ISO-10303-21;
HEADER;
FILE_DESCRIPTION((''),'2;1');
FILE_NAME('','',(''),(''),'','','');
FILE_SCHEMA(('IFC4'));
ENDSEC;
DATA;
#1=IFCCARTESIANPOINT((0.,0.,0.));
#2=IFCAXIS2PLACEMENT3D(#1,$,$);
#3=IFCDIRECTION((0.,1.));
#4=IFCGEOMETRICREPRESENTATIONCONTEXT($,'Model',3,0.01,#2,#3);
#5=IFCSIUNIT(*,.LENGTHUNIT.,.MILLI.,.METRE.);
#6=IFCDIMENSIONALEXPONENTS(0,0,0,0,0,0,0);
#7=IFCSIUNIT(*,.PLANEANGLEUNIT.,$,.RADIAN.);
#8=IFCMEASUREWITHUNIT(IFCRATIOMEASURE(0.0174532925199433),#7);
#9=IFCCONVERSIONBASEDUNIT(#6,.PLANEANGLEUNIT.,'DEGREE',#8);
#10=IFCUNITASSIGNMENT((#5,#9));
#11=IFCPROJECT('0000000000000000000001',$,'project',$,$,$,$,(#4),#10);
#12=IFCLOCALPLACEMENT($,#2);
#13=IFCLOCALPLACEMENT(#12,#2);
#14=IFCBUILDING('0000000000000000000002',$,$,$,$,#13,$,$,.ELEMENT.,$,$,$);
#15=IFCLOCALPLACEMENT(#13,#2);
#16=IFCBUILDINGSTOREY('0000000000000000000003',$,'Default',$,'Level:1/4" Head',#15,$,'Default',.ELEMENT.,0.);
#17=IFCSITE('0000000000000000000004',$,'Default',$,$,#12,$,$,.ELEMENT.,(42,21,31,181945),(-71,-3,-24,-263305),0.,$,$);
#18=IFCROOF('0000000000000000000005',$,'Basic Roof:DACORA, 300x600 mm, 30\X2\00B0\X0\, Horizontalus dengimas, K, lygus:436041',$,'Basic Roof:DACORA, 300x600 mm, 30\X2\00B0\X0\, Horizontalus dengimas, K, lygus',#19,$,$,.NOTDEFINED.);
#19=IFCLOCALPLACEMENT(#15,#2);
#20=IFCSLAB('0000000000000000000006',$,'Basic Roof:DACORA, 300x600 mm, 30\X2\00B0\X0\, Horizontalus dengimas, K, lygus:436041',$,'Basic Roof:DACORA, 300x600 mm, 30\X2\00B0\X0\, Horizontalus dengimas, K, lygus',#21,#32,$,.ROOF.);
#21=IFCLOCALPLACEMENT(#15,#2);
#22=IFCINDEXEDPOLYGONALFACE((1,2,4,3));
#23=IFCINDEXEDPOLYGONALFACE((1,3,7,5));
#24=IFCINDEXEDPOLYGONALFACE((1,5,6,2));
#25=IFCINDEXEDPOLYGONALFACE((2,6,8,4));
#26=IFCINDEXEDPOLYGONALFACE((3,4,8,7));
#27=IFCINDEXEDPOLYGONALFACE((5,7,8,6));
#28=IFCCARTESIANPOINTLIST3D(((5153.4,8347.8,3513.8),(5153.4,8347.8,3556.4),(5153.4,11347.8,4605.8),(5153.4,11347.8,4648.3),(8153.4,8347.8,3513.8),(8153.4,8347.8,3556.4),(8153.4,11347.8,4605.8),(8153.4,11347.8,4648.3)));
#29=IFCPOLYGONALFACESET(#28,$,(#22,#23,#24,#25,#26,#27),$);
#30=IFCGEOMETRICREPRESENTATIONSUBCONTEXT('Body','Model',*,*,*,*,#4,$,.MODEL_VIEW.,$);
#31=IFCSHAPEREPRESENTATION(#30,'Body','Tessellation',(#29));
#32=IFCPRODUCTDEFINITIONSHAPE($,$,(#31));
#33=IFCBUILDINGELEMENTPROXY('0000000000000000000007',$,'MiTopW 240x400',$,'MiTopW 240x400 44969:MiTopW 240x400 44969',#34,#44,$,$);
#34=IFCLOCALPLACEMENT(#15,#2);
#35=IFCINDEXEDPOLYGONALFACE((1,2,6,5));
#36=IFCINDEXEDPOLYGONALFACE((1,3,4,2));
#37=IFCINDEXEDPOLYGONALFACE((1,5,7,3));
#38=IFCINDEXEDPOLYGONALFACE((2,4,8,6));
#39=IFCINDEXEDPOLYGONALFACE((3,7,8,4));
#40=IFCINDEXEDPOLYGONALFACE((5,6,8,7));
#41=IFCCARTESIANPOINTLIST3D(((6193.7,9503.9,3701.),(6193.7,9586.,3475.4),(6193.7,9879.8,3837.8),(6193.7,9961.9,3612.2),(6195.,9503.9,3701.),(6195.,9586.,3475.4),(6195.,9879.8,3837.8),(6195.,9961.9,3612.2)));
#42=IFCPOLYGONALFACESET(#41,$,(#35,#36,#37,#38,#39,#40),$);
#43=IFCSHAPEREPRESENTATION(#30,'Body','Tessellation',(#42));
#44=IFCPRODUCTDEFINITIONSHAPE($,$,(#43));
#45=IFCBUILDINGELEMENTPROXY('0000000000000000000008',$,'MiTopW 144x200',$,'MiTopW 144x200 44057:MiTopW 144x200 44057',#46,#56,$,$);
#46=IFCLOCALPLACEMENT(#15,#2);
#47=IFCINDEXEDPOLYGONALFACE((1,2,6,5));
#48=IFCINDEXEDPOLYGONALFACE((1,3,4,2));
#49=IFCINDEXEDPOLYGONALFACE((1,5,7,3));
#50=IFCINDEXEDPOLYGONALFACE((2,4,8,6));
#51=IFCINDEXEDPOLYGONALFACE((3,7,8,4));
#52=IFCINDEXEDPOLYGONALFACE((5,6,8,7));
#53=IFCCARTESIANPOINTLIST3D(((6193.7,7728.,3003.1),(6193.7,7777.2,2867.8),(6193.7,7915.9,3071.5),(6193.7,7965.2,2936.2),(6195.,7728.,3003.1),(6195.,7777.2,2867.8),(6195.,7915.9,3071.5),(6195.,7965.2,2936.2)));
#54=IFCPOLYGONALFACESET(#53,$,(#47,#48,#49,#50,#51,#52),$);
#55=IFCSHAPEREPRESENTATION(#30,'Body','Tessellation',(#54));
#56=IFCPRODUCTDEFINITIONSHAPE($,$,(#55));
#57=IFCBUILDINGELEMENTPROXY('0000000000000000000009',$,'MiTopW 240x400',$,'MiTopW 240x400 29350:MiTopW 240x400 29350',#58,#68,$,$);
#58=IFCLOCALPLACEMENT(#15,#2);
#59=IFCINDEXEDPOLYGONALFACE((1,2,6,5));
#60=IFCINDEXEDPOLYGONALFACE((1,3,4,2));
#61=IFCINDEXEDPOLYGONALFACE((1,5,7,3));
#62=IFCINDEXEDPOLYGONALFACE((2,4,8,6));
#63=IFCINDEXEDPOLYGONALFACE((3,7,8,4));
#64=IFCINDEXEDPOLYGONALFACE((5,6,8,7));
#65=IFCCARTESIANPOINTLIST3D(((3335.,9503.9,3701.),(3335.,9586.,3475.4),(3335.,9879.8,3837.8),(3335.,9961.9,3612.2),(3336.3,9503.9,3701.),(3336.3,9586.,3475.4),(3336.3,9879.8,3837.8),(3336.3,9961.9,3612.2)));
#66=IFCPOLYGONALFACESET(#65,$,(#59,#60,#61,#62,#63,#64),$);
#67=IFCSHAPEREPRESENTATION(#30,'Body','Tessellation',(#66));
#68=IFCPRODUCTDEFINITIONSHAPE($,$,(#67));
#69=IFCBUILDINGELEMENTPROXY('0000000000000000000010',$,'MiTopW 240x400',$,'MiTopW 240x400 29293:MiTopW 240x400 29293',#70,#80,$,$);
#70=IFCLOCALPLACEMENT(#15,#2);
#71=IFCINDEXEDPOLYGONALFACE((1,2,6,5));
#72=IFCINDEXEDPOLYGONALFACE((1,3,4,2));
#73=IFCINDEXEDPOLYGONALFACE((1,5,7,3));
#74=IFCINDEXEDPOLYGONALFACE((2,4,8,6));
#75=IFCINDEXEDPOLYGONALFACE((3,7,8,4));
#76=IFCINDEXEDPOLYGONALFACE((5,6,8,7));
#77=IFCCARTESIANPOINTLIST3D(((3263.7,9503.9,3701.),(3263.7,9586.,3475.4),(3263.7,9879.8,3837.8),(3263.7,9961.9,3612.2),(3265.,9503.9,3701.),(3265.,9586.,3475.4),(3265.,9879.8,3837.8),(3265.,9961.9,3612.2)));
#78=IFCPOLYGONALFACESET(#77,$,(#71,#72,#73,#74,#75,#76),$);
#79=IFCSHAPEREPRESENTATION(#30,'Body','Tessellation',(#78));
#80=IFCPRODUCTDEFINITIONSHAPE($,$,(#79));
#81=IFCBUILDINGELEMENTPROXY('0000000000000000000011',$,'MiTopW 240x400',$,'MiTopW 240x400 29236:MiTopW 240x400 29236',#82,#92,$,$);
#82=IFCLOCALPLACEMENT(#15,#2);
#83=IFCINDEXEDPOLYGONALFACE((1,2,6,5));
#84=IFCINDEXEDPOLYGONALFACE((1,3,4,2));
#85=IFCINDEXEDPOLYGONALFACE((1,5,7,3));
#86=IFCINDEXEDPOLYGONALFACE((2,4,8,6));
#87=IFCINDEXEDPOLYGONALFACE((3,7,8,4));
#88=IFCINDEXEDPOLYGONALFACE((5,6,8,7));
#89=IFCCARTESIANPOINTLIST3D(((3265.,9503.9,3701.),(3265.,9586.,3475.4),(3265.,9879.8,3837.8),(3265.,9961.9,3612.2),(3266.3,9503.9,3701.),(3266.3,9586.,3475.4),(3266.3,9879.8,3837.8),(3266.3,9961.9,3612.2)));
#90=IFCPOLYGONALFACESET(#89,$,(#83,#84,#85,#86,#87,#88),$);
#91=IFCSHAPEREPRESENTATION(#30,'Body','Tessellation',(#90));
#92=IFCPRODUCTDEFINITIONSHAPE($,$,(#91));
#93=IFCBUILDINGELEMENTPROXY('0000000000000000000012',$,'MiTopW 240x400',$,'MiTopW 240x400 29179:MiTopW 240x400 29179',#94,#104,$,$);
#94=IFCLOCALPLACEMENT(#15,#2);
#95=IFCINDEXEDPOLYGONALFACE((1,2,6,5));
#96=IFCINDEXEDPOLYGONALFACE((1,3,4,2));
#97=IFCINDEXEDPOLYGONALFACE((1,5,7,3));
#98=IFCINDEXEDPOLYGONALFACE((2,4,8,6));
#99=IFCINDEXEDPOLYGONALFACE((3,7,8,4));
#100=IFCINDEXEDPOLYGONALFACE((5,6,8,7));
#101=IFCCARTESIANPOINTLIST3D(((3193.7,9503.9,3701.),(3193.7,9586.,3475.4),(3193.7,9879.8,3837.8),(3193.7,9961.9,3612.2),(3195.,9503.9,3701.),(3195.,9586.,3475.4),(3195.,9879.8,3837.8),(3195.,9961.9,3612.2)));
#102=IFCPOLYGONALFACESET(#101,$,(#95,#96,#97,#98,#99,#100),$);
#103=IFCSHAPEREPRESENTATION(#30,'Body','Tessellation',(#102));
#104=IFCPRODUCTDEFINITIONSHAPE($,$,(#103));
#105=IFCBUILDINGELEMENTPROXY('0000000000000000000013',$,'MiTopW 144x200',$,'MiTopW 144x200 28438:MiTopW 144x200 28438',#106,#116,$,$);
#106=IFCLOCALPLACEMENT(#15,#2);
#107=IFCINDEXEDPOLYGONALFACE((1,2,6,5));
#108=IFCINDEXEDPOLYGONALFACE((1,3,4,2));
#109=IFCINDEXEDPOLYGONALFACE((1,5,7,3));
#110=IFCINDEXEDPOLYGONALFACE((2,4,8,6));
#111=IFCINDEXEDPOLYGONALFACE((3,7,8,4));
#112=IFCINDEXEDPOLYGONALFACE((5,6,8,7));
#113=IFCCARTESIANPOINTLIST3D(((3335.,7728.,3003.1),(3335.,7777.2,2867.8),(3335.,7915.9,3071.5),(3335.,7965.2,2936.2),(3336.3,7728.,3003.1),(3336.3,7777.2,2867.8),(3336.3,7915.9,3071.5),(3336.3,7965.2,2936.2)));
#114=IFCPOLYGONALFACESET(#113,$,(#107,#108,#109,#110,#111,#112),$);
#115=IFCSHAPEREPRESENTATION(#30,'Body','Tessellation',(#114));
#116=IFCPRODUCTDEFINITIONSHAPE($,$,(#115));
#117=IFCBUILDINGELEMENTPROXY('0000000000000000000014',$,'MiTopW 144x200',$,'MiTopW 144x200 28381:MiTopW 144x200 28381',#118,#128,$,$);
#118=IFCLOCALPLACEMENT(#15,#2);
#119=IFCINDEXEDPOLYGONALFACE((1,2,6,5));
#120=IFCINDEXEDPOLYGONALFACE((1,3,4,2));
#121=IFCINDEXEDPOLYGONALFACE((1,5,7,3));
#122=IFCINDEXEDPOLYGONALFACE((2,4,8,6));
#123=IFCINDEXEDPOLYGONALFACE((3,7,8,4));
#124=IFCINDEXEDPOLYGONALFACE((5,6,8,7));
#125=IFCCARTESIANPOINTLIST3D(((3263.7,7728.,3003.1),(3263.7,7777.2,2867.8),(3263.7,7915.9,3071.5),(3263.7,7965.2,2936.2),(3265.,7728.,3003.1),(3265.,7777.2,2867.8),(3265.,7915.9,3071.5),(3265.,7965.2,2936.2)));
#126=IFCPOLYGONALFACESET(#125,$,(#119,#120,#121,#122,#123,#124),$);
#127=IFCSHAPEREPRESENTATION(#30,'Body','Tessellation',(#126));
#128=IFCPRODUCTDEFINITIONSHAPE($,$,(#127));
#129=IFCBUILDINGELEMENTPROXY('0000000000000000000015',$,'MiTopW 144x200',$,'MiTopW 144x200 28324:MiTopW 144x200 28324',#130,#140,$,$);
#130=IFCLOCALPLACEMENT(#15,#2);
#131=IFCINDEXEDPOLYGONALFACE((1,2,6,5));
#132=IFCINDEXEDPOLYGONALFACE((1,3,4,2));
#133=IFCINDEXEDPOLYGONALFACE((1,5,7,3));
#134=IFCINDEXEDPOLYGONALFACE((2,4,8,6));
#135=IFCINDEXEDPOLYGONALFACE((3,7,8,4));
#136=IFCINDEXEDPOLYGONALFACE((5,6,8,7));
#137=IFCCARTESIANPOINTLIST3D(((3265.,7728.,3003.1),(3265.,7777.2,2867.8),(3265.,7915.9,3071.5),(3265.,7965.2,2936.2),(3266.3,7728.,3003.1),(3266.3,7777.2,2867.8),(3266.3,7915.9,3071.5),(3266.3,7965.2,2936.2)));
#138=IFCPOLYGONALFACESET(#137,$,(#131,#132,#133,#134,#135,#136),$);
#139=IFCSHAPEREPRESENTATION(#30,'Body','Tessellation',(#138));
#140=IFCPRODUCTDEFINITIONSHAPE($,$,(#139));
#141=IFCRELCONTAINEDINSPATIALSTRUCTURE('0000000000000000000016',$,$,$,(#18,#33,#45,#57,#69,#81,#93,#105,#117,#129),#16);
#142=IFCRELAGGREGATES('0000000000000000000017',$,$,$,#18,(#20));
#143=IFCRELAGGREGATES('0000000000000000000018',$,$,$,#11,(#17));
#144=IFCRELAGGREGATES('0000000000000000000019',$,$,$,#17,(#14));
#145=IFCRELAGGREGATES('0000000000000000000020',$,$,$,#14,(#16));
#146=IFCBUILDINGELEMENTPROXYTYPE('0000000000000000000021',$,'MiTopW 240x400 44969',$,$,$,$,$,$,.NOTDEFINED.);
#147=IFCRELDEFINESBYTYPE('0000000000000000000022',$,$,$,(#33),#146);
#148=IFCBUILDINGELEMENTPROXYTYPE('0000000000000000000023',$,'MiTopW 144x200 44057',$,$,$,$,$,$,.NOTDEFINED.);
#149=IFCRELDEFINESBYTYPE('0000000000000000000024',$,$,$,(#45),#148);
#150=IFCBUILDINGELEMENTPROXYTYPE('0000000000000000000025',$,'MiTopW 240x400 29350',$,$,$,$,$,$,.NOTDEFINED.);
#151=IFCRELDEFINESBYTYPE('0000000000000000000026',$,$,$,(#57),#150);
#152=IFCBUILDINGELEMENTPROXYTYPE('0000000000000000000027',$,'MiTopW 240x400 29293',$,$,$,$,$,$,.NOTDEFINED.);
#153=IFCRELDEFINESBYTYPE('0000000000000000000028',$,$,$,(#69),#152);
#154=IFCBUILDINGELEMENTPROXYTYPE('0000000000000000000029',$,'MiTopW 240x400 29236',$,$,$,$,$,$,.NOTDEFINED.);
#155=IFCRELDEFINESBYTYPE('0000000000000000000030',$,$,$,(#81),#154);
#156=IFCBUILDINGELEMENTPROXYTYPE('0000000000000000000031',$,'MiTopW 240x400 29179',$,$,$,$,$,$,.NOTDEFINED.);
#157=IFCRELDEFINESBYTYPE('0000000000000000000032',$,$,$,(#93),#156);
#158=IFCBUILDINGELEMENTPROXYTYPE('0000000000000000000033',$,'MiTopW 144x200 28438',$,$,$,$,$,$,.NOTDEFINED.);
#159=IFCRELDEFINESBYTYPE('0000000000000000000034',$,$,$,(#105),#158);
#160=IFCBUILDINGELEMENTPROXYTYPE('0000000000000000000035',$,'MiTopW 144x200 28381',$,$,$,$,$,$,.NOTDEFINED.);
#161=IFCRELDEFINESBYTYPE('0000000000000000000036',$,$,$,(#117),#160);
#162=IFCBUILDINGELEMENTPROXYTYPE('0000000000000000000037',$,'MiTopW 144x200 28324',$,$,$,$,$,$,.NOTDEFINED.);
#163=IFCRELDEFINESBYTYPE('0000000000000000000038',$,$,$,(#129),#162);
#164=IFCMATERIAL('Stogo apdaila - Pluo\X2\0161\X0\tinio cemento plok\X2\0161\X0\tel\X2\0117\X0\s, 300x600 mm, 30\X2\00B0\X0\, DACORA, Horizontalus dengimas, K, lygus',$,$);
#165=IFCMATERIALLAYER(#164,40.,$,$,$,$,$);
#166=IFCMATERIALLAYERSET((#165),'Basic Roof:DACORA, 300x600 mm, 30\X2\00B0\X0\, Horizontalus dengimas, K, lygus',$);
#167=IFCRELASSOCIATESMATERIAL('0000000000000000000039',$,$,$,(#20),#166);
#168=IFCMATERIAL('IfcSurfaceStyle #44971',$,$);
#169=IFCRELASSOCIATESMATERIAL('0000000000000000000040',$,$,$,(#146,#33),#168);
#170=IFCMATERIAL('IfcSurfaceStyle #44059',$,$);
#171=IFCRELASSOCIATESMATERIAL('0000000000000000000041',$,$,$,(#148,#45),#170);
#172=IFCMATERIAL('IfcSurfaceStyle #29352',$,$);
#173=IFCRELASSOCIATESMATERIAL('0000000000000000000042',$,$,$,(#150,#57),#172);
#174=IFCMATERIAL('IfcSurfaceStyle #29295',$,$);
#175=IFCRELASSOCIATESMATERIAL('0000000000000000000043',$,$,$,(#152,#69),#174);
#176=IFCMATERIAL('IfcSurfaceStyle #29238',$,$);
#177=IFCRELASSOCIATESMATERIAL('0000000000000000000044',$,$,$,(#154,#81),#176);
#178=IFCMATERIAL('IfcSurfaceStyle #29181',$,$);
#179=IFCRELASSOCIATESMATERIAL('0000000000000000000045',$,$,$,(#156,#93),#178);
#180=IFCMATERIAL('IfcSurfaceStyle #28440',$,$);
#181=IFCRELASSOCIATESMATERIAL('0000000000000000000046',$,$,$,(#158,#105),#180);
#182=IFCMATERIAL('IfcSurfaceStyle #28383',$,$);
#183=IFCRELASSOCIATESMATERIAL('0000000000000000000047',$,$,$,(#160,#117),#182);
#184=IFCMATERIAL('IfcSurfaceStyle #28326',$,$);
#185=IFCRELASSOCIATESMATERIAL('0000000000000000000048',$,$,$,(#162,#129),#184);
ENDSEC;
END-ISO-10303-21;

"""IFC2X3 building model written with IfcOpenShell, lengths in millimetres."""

from ifc_helpers import new_model, entity, si_unit, converted_unit, direction, frame, frame_2d, origin, place, context, subcontext, project, spatial, polyline, rectangle, outline, extrude, source, transform, mapped, material, layer, layer_set, type_object, type_shapes, element, aggregate, save


model = new_model("IFC2X3")

# Units and contexts
model_context = context("Model", 3, precision=0.01, world=origin(), true_north=direction((0.0, 1.0)))
body_context = subcontext(model_context, "Body", "Model", "MODEL_VIEW")
ifc_project = project(units=[si_unit("LENGTHUNIT", "METRE", prefix="MILLI"), converted_unit("PLANEANGLEUNIT", "DEGREE", entity("IfcRatioMeasure", 0.0174532925199433), si_unit("PLANEANGLEUNIT", "RADIAN"), dimensions=[0, 0, 0, 0, 0, 0, 0])], contexts=[model_context])

# Site, building, storey
site_placement = place(None, origin())
site = spatial("IfcSite", under=ifc_project, at=site_placement, Name="Default", CompositionType="ELEMENT", RefLatitude=(42, 21, 31, 181945), RefLongitude=(-71, -3, -24, -263305), RefElevation=0.0)
building_placement = place(site_placement, origin())
building = spatial("IfcBuilding", under=site, at=building_placement, CompositionType="ELEMENT")
storey_placement = place(building_placement, origin())
storey = spatial("IfcBuildingStorey", under=building, at=storey_placement, Name="Default", ObjectType="Level:1/4\" Head", LongName="Default", CompositionType="ELEMENT", Elevation=0.0)

# Roof, slab
roof_placement = place(storey_placement, frame((5153.4, 8347.8, 3513.8)))
roof = element("IfcRoof", 1, at=roof_placement, inside=storey, Name="Basic Roof:DACORA, 300x600 mm, 30°, Horizontalus dengimas, K, lygus:436041", ObjectType="Basic Roof:DACORA, 300x600 mm, 30°, Horizontalus dengimas, K, lygus", ShapeType="NOTDEFINED")
ifc_material_1 = material(Name="Stogo apdaila - Pluoštinio cemento plokštelės, 300x600 mm, 30°, DACORA, Horizontalus dengimas, K, lygus")
ifc_layer = layer(ifc_material_1, 40.0)
ifc_layer_set = layer_set([ifc_layer], Name="Basic Roof:DACORA, 300x600 mm, 30°, Horizontalus dengimas, K, lygus")
slab_placement = place(roof_placement, origin())
slab = element("IfcSlab", 2, at=slab_placement, material=ifc_layer_set, Name="Basic Roof:DACORA, 300x600 mm, 30°, Horizontalus dengimas, K, lygus:436041", ObjectType="Basic Roof:DACORA, 300x600 mm, 30°, Horizontalus dengimas, K, lygus", PredefinedType="ROOF", context=body_context, shape_type="SweptSolid", body=[
    extrude(rectangle(XDim=3192.5, YDim=3000.0, at=frame_2d((0.0, 0.0), x_axis=(0.0, -1.0))), frame((1500.0, 1500.0, 546.0), z_axis=(0.0, -0.34202, 0.939693), x_axis=(1.0, 0.0, 0.0)), (0.0, 0.34202, 0.939693), 42.6),
])
aggregate(roof, [slab])

# Building element proxies
ifc_material_2 = material(Name="IfcSurfaceStyle #44971")
building_element_proxy_type_1 = type_object("IfcBuildingElementProxyType", Name="MiTopW 240x400 44969", PredefinedType="NOTDEFINED", material=ifc_material_2)
shared_shape_1 = source(origin(), body_context, "Body", "SweptSolid", [
    extrude(outline(polyline([(-200.0, -120.0), (200.0, -120.0), (200.0, 120.0), (-200.0, 120.0), (-200.0, -120.0)])), frame((200.0, 120.0, 0.0), z_axis=(0.0, 0.0, 1.0), x_axis=(-1.0, 0.0, 0.0)), (0.0, 0.0, 1.0), 1.3),
])
type_shapes(building_element_proxy_type_1, [shared_shape_1])
proxy_1_placement = place(building_placement, frame((6195.0, 9961.9, 3612.2), z_axis=(-1.0, 0.0, 0.0), x_axis=(0.0, -0.939693, -0.34202)))
element("IfcBuildingElementProxy", 3, at=proxy_1_placement, inside=storey, type_object=building_element_proxy_type_1, material=ifc_material_2, Name="MiTopW 240x400", ObjectType="MiTopW 240x400 44969:MiTopW 240x400 44969", context=body_context, shape_type="MappedRepresentation", body=[
    mapped(shared_shape_1, transform((0.0, 0.0, 0.0), scale=1.0)),
])
ifc_material_3 = material(Name="IfcSurfaceStyle #44059")
building_element_proxy_type_2 = type_object("IfcBuildingElementProxyType", Name="MiTopW 144x200 44057", PredefinedType="NOTDEFINED", material=ifc_material_3)
shared_shape_2 = source(origin(), body_context, "Body", "SweptSolid", [
    extrude(outline(polyline([(-100.0, -72.0), (100.0, -72.0), (100.0, 72.0), (-100.0, 72.0), (-100.0, -72.0)])), frame((100.0, 72.0, 0.0), z_axis=(0.0, 0.0, 1.0), x_axis=(-1.0, 0.0, 0.0)), (0.0, 0.0, 1.0), 1.3),
])
type_shapes(building_element_proxy_type_2, [shared_shape_2])
proxy_2_placement = place(building_placement, frame((6195.0, 7965.2, 2936.2), z_axis=(-1.0, 0.0, 0.0), x_axis=(0.0, -0.939693, -0.34202)))
element("IfcBuildingElementProxy", 4, at=proxy_2_placement, inside=storey, type_object=building_element_proxy_type_2, material=ifc_material_3, Name="MiTopW 144x200", ObjectType="MiTopW 144x200 44057:MiTopW 144x200 44057", context=body_context, shape_type="MappedRepresentation", body=[
    mapped(shared_shape_2, transform((0.0, 0.0, 0.0), scale=1.0)),
])
ifc_material_4 = material(Name="IfcSurfaceStyle #29352")
building_element_proxy_type_3 = type_object("IfcBuildingElementProxyType", Name="MiTopW 240x400 29350", PredefinedType="NOTDEFINED", material=ifc_material_4)
shared_shape_3 = source(origin(), body_context, "Body", "SweptSolid", [
    extrude(outline(polyline([(-200.0, -120.0), (200.0, -120.0), (200.0, 120.0), (-200.0, 120.0), (-200.0, -120.0)])), frame((200.0, 120.0, 0.0), z_axis=(0.0, 0.0, 1.0), x_axis=(-1.0, 0.0, 0.0)), (0.0, 0.0, 1.0), 1.3),
])
type_shapes(building_element_proxy_type_3, [shared_shape_3])
proxy_3_placement = place(building_placement, frame((3336.3, 9961.9, 3612.2), z_axis=(-1.0, 0.0, 0.0), x_axis=(0.0, -0.939693, -0.34202)))
element("IfcBuildingElementProxy", 5, at=proxy_3_placement, inside=storey, type_object=building_element_proxy_type_3, material=ifc_material_4, Name="MiTopW 240x400", ObjectType="MiTopW 240x400 29350:MiTopW 240x400 29350", context=body_context, shape_type="MappedRepresentation", body=[
    mapped(shared_shape_3, transform((0.0, 0.0, 0.0), scale=1.0)),
])
ifc_material_5 = material(Name="IfcSurfaceStyle #29295")
building_element_proxy_type_4 = type_object("IfcBuildingElementProxyType", Name="MiTopW 240x400 29293", PredefinedType="NOTDEFINED", material=ifc_material_5)
shared_shape_4 = source(origin(), body_context, "Body", "SweptSolid", [
    extrude(outline(polyline([(-200.0, -120.0), (200.0, -120.0), (200.0, 120.0), (-200.0, 120.0), (-200.0, -120.0)])), frame((200.0, 120.0, 0.0), z_axis=(0.0, 0.0, 1.0), x_axis=(-1.0, 0.0, 0.0)), (0.0, 0.0, 1.0), 1.3),
])
type_shapes(building_element_proxy_type_4, [shared_shape_4])
proxy_4_placement = place(building_placement, frame((3265.0, 9961.9, 3612.2), z_axis=(-1.0, 0.0, 0.0), x_axis=(0.0, -0.939693, -0.34202)))
element("IfcBuildingElementProxy", 6, at=proxy_4_placement, inside=storey, type_object=building_element_proxy_type_4, material=ifc_material_5, Name="MiTopW 240x400", ObjectType="MiTopW 240x400 29293:MiTopW 240x400 29293", context=body_context, shape_type="MappedRepresentation", body=[
    mapped(shared_shape_4, transform((0.0, 0.0, 0.0), scale=1.0)),
])
ifc_material_6 = material(Name="IfcSurfaceStyle #29238")
building_element_proxy_type_5 = type_object("IfcBuildingElementProxyType", Name="MiTopW 240x400 29236", PredefinedType="NOTDEFINED", material=ifc_material_6)
shared_shape_5 = source(origin(), body_context, "Body", "SweptSolid", [
    extrude(outline(polyline([(-200.0, -120.0), (200.0, -120.0), (200.0, 120.0), (-200.0, 120.0), (-200.0, -120.0)])), frame((200.0, 120.0, 0.0), z_axis=(0.0, 0.0, 1.0), x_axis=(-1.0, 0.0, 0.0)), (0.0, 0.0, 1.0), 1.3),
])
type_shapes(building_element_proxy_type_5, [shared_shape_5])
proxy_5_placement = place(building_placement, frame((3266.3, 9961.9, 3612.2), z_axis=(-1.0, 0.0, 0.0), x_axis=(0.0, -0.939693, -0.34202)))
element("IfcBuildingElementProxy", 7, at=proxy_5_placement, inside=storey, type_object=building_element_proxy_type_5, material=ifc_material_6, Name="MiTopW 240x400", ObjectType="MiTopW 240x400 29236:MiTopW 240x400 29236", context=body_context, shape_type="MappedRepresentation", body=[
    mapped(shared_shape_5, transform((0.0, 0.0, 0.0), scale=1.0)),
])
ifc_material_7 = material(Name="IfcSurfaceStyle #29181")
building_element_proxy_type_6 = type_object("IfcBuildingElementProxyType", Name="MiTopW 240x400 29179", PredefinedType="NOTDEFINED", material=ifc_material_7)
shared_shape_6 = source(origin(), body_context, "Body", "SweptSolid", [
    extrude(outline(polyline([(-200.0, -120.0), (200.0, -120.0), (200.0, 120.0), (-200.0, 120.0), (-200.0, -120.0)])), frame((200.0, 120.0, 0.0), z_axis=(0.0, 0.0, 1.0), x_axis=(-1.0, 0.0, 0.0)), (0.0, 0.0, 1.0), 1.3),
])
type_shapes(building_element_proxy_type_6, [shared_shape_6])
proxy_6_placement = place(building_placement, frame((3195.0, 9961.9, 3612.2), z_axis=(-1.0, 0.0, 0.0), x_axis=(0.0, -0.939693, -0.34202)))
element("IfcBuildingElementProxy", 8, at=proxy_6_placement, inside=storey, type_object=building_element_proxy_type_6, material=ifc_material_7, Name="MiTopW 240x400", ObjectType="MiTopW 240x400 29179:MiTopW 240x400 29179", context=body_context, shape_type="MappedRepresentation", body=[
    mapped(shared_shape_6, transform((0.0, 0.0, 0.0), scale=1.0)),
])
ifc_material_8 = material(Name="IfcSurfaceStyle #28440")
building_element_proxy_type_7 = type_object("IfcBuildingElementProxyType", Name="MiTopW 144x200 28438", PredefinedType="NOTDEFINED", material=ifc_material_8)
shared_shape_7 = source(origin(), body_context, "Body", "SweptSolid", [
    extrude(outline(polyline([(-100.0, -72.0), (100.0, -72.0), (100.0, 72.0), (-100.0, 72.0), (-100.0, -72.0)])), frame((100.0, 72.0, 0.0), z_axis=(0.0, 0.0, 1.0), x_axis=(-1.0, 0.0, 0.0)), (0.0, 0.0, 1.0), 1.3),
])
type_shapes(building_element_proxy_type_7, [shared_shape_7])
proxy_7_placement = place(building_placement, frame((3336.3, 7965.2, 2936.2), z_axis=(-1.0, 0.0, 0.0), x_axis=(0.0, -0.939693, -0.34202)))
element("IfcBuildingElementProxy", 9, at=proxy_7_placement, inside=storey, type_object=building_element_proxy_type_7, material=ifc_material_8, Name="MiTopW 144x200", ObjectType="MiTopW 144x200 28438:MiTopW 144x200 28438", context=body_context, shape_type="MappedRepresentation", body=[
    mapped(shared_shape_7, transform((0.0, 0.0, 0.0), scale=1.0)),
])
ifc_material_9 = material(Name="IfcSurfaceStyle #28383")
building_element_proxy_type_8 = type_object("IfcBuildingElementProxyType", Name="MiTopW 144x200 28381", PredefinedType="NOTDEFINED", material=ifc_material_9)
shared_shape_8 = source(origin(), body_context, "Body", "SweptSolid", [
    extrude(outline(polyline([(-100.0, -72.0), (100.0, -72.0), (100.0, 72.0), (-100.0, 72.0), (-100.0, -72.0)])), frame((100.0, 72.0, 0.0), z_axis=(0.0, 0.0, 1.0), x_axis=(-1.0, 0.0, 0.0)), (0.0, 0.0, 1.0), 1.3),
])
type_shapes(building_element_proxy_type_8, [shared_shape_8])
proxy_8_placement = place(building_placement, frame((3265.0, 7965.2, 2936.2), z_axis=(-1.0, 0.0, 0.0), x_axis=(0.0, -0.939693, -0.34202)))
element("IfcBuildingElementProxy", 10, at=proxy_8_placement, inside=storey, type_object=building_element_proxy_type_8, material=ifc_material_9, Name="MiTopW 144x200", ObjectType="MiTopW 144x200 28381:MiTopW 144x200 28381", context=body_context, shape_type="MappedRepresentation", body=[
    mapped(shared_shape_8, transform((0.0, 0.0, 0.0), scale=1.0)),
])
ifc_material_10 = material(Name="IfcSurfaceStyle #28326")
building_element_proxy_type_9 = type_object("IfcBuildingElementProxyType", Name="MiTopW 144x200 28324", PredefinedType="NOTDEFINED", material=ifc_material_10)
shared_shape_9 = source(origin(), body_context, "Body", "SweptSolid", [
    extrude(outline(polyline([(-100.0, -72.0), (100.0, -72.0), (100.0, 72.0), (-100.0, 72.0), (-100.0, -72.0)])), frame((100.0, 72.0, 0.0), z_axis=(0.0, 0.0, 1.0), x_axis=(-1.0, 0.0, 0.0)), (0.0, 0.0, 1.0), 1.3),
])
type_shapes(building_element_proxy_type_9, [shared_shape_9])
proxy_9_placement = place(building_placement, frame((3266.3, 7965.2, 2936.2), z_axis=(-1.0, 0.0, 0.0), x_axis=(0.0, -0.939693, -0.34202)))
element("IfcBuildingElementProxy", 11, at=proxy_9_placement, inside=storey, type_object=building_element_proxy_type_9, material=ifc_material_10, Name="MiTopW 144x200", ObjectType="MiTopW 144x200 28324:MiTopW 144x200 28324", context=body_context, shape_type="MappedRepresentation", body=[
    mapped(shared_shape_9, transform((0.0, 0.0, 0.0), scale=1.0)),
])

save(model, "model.ifc")
